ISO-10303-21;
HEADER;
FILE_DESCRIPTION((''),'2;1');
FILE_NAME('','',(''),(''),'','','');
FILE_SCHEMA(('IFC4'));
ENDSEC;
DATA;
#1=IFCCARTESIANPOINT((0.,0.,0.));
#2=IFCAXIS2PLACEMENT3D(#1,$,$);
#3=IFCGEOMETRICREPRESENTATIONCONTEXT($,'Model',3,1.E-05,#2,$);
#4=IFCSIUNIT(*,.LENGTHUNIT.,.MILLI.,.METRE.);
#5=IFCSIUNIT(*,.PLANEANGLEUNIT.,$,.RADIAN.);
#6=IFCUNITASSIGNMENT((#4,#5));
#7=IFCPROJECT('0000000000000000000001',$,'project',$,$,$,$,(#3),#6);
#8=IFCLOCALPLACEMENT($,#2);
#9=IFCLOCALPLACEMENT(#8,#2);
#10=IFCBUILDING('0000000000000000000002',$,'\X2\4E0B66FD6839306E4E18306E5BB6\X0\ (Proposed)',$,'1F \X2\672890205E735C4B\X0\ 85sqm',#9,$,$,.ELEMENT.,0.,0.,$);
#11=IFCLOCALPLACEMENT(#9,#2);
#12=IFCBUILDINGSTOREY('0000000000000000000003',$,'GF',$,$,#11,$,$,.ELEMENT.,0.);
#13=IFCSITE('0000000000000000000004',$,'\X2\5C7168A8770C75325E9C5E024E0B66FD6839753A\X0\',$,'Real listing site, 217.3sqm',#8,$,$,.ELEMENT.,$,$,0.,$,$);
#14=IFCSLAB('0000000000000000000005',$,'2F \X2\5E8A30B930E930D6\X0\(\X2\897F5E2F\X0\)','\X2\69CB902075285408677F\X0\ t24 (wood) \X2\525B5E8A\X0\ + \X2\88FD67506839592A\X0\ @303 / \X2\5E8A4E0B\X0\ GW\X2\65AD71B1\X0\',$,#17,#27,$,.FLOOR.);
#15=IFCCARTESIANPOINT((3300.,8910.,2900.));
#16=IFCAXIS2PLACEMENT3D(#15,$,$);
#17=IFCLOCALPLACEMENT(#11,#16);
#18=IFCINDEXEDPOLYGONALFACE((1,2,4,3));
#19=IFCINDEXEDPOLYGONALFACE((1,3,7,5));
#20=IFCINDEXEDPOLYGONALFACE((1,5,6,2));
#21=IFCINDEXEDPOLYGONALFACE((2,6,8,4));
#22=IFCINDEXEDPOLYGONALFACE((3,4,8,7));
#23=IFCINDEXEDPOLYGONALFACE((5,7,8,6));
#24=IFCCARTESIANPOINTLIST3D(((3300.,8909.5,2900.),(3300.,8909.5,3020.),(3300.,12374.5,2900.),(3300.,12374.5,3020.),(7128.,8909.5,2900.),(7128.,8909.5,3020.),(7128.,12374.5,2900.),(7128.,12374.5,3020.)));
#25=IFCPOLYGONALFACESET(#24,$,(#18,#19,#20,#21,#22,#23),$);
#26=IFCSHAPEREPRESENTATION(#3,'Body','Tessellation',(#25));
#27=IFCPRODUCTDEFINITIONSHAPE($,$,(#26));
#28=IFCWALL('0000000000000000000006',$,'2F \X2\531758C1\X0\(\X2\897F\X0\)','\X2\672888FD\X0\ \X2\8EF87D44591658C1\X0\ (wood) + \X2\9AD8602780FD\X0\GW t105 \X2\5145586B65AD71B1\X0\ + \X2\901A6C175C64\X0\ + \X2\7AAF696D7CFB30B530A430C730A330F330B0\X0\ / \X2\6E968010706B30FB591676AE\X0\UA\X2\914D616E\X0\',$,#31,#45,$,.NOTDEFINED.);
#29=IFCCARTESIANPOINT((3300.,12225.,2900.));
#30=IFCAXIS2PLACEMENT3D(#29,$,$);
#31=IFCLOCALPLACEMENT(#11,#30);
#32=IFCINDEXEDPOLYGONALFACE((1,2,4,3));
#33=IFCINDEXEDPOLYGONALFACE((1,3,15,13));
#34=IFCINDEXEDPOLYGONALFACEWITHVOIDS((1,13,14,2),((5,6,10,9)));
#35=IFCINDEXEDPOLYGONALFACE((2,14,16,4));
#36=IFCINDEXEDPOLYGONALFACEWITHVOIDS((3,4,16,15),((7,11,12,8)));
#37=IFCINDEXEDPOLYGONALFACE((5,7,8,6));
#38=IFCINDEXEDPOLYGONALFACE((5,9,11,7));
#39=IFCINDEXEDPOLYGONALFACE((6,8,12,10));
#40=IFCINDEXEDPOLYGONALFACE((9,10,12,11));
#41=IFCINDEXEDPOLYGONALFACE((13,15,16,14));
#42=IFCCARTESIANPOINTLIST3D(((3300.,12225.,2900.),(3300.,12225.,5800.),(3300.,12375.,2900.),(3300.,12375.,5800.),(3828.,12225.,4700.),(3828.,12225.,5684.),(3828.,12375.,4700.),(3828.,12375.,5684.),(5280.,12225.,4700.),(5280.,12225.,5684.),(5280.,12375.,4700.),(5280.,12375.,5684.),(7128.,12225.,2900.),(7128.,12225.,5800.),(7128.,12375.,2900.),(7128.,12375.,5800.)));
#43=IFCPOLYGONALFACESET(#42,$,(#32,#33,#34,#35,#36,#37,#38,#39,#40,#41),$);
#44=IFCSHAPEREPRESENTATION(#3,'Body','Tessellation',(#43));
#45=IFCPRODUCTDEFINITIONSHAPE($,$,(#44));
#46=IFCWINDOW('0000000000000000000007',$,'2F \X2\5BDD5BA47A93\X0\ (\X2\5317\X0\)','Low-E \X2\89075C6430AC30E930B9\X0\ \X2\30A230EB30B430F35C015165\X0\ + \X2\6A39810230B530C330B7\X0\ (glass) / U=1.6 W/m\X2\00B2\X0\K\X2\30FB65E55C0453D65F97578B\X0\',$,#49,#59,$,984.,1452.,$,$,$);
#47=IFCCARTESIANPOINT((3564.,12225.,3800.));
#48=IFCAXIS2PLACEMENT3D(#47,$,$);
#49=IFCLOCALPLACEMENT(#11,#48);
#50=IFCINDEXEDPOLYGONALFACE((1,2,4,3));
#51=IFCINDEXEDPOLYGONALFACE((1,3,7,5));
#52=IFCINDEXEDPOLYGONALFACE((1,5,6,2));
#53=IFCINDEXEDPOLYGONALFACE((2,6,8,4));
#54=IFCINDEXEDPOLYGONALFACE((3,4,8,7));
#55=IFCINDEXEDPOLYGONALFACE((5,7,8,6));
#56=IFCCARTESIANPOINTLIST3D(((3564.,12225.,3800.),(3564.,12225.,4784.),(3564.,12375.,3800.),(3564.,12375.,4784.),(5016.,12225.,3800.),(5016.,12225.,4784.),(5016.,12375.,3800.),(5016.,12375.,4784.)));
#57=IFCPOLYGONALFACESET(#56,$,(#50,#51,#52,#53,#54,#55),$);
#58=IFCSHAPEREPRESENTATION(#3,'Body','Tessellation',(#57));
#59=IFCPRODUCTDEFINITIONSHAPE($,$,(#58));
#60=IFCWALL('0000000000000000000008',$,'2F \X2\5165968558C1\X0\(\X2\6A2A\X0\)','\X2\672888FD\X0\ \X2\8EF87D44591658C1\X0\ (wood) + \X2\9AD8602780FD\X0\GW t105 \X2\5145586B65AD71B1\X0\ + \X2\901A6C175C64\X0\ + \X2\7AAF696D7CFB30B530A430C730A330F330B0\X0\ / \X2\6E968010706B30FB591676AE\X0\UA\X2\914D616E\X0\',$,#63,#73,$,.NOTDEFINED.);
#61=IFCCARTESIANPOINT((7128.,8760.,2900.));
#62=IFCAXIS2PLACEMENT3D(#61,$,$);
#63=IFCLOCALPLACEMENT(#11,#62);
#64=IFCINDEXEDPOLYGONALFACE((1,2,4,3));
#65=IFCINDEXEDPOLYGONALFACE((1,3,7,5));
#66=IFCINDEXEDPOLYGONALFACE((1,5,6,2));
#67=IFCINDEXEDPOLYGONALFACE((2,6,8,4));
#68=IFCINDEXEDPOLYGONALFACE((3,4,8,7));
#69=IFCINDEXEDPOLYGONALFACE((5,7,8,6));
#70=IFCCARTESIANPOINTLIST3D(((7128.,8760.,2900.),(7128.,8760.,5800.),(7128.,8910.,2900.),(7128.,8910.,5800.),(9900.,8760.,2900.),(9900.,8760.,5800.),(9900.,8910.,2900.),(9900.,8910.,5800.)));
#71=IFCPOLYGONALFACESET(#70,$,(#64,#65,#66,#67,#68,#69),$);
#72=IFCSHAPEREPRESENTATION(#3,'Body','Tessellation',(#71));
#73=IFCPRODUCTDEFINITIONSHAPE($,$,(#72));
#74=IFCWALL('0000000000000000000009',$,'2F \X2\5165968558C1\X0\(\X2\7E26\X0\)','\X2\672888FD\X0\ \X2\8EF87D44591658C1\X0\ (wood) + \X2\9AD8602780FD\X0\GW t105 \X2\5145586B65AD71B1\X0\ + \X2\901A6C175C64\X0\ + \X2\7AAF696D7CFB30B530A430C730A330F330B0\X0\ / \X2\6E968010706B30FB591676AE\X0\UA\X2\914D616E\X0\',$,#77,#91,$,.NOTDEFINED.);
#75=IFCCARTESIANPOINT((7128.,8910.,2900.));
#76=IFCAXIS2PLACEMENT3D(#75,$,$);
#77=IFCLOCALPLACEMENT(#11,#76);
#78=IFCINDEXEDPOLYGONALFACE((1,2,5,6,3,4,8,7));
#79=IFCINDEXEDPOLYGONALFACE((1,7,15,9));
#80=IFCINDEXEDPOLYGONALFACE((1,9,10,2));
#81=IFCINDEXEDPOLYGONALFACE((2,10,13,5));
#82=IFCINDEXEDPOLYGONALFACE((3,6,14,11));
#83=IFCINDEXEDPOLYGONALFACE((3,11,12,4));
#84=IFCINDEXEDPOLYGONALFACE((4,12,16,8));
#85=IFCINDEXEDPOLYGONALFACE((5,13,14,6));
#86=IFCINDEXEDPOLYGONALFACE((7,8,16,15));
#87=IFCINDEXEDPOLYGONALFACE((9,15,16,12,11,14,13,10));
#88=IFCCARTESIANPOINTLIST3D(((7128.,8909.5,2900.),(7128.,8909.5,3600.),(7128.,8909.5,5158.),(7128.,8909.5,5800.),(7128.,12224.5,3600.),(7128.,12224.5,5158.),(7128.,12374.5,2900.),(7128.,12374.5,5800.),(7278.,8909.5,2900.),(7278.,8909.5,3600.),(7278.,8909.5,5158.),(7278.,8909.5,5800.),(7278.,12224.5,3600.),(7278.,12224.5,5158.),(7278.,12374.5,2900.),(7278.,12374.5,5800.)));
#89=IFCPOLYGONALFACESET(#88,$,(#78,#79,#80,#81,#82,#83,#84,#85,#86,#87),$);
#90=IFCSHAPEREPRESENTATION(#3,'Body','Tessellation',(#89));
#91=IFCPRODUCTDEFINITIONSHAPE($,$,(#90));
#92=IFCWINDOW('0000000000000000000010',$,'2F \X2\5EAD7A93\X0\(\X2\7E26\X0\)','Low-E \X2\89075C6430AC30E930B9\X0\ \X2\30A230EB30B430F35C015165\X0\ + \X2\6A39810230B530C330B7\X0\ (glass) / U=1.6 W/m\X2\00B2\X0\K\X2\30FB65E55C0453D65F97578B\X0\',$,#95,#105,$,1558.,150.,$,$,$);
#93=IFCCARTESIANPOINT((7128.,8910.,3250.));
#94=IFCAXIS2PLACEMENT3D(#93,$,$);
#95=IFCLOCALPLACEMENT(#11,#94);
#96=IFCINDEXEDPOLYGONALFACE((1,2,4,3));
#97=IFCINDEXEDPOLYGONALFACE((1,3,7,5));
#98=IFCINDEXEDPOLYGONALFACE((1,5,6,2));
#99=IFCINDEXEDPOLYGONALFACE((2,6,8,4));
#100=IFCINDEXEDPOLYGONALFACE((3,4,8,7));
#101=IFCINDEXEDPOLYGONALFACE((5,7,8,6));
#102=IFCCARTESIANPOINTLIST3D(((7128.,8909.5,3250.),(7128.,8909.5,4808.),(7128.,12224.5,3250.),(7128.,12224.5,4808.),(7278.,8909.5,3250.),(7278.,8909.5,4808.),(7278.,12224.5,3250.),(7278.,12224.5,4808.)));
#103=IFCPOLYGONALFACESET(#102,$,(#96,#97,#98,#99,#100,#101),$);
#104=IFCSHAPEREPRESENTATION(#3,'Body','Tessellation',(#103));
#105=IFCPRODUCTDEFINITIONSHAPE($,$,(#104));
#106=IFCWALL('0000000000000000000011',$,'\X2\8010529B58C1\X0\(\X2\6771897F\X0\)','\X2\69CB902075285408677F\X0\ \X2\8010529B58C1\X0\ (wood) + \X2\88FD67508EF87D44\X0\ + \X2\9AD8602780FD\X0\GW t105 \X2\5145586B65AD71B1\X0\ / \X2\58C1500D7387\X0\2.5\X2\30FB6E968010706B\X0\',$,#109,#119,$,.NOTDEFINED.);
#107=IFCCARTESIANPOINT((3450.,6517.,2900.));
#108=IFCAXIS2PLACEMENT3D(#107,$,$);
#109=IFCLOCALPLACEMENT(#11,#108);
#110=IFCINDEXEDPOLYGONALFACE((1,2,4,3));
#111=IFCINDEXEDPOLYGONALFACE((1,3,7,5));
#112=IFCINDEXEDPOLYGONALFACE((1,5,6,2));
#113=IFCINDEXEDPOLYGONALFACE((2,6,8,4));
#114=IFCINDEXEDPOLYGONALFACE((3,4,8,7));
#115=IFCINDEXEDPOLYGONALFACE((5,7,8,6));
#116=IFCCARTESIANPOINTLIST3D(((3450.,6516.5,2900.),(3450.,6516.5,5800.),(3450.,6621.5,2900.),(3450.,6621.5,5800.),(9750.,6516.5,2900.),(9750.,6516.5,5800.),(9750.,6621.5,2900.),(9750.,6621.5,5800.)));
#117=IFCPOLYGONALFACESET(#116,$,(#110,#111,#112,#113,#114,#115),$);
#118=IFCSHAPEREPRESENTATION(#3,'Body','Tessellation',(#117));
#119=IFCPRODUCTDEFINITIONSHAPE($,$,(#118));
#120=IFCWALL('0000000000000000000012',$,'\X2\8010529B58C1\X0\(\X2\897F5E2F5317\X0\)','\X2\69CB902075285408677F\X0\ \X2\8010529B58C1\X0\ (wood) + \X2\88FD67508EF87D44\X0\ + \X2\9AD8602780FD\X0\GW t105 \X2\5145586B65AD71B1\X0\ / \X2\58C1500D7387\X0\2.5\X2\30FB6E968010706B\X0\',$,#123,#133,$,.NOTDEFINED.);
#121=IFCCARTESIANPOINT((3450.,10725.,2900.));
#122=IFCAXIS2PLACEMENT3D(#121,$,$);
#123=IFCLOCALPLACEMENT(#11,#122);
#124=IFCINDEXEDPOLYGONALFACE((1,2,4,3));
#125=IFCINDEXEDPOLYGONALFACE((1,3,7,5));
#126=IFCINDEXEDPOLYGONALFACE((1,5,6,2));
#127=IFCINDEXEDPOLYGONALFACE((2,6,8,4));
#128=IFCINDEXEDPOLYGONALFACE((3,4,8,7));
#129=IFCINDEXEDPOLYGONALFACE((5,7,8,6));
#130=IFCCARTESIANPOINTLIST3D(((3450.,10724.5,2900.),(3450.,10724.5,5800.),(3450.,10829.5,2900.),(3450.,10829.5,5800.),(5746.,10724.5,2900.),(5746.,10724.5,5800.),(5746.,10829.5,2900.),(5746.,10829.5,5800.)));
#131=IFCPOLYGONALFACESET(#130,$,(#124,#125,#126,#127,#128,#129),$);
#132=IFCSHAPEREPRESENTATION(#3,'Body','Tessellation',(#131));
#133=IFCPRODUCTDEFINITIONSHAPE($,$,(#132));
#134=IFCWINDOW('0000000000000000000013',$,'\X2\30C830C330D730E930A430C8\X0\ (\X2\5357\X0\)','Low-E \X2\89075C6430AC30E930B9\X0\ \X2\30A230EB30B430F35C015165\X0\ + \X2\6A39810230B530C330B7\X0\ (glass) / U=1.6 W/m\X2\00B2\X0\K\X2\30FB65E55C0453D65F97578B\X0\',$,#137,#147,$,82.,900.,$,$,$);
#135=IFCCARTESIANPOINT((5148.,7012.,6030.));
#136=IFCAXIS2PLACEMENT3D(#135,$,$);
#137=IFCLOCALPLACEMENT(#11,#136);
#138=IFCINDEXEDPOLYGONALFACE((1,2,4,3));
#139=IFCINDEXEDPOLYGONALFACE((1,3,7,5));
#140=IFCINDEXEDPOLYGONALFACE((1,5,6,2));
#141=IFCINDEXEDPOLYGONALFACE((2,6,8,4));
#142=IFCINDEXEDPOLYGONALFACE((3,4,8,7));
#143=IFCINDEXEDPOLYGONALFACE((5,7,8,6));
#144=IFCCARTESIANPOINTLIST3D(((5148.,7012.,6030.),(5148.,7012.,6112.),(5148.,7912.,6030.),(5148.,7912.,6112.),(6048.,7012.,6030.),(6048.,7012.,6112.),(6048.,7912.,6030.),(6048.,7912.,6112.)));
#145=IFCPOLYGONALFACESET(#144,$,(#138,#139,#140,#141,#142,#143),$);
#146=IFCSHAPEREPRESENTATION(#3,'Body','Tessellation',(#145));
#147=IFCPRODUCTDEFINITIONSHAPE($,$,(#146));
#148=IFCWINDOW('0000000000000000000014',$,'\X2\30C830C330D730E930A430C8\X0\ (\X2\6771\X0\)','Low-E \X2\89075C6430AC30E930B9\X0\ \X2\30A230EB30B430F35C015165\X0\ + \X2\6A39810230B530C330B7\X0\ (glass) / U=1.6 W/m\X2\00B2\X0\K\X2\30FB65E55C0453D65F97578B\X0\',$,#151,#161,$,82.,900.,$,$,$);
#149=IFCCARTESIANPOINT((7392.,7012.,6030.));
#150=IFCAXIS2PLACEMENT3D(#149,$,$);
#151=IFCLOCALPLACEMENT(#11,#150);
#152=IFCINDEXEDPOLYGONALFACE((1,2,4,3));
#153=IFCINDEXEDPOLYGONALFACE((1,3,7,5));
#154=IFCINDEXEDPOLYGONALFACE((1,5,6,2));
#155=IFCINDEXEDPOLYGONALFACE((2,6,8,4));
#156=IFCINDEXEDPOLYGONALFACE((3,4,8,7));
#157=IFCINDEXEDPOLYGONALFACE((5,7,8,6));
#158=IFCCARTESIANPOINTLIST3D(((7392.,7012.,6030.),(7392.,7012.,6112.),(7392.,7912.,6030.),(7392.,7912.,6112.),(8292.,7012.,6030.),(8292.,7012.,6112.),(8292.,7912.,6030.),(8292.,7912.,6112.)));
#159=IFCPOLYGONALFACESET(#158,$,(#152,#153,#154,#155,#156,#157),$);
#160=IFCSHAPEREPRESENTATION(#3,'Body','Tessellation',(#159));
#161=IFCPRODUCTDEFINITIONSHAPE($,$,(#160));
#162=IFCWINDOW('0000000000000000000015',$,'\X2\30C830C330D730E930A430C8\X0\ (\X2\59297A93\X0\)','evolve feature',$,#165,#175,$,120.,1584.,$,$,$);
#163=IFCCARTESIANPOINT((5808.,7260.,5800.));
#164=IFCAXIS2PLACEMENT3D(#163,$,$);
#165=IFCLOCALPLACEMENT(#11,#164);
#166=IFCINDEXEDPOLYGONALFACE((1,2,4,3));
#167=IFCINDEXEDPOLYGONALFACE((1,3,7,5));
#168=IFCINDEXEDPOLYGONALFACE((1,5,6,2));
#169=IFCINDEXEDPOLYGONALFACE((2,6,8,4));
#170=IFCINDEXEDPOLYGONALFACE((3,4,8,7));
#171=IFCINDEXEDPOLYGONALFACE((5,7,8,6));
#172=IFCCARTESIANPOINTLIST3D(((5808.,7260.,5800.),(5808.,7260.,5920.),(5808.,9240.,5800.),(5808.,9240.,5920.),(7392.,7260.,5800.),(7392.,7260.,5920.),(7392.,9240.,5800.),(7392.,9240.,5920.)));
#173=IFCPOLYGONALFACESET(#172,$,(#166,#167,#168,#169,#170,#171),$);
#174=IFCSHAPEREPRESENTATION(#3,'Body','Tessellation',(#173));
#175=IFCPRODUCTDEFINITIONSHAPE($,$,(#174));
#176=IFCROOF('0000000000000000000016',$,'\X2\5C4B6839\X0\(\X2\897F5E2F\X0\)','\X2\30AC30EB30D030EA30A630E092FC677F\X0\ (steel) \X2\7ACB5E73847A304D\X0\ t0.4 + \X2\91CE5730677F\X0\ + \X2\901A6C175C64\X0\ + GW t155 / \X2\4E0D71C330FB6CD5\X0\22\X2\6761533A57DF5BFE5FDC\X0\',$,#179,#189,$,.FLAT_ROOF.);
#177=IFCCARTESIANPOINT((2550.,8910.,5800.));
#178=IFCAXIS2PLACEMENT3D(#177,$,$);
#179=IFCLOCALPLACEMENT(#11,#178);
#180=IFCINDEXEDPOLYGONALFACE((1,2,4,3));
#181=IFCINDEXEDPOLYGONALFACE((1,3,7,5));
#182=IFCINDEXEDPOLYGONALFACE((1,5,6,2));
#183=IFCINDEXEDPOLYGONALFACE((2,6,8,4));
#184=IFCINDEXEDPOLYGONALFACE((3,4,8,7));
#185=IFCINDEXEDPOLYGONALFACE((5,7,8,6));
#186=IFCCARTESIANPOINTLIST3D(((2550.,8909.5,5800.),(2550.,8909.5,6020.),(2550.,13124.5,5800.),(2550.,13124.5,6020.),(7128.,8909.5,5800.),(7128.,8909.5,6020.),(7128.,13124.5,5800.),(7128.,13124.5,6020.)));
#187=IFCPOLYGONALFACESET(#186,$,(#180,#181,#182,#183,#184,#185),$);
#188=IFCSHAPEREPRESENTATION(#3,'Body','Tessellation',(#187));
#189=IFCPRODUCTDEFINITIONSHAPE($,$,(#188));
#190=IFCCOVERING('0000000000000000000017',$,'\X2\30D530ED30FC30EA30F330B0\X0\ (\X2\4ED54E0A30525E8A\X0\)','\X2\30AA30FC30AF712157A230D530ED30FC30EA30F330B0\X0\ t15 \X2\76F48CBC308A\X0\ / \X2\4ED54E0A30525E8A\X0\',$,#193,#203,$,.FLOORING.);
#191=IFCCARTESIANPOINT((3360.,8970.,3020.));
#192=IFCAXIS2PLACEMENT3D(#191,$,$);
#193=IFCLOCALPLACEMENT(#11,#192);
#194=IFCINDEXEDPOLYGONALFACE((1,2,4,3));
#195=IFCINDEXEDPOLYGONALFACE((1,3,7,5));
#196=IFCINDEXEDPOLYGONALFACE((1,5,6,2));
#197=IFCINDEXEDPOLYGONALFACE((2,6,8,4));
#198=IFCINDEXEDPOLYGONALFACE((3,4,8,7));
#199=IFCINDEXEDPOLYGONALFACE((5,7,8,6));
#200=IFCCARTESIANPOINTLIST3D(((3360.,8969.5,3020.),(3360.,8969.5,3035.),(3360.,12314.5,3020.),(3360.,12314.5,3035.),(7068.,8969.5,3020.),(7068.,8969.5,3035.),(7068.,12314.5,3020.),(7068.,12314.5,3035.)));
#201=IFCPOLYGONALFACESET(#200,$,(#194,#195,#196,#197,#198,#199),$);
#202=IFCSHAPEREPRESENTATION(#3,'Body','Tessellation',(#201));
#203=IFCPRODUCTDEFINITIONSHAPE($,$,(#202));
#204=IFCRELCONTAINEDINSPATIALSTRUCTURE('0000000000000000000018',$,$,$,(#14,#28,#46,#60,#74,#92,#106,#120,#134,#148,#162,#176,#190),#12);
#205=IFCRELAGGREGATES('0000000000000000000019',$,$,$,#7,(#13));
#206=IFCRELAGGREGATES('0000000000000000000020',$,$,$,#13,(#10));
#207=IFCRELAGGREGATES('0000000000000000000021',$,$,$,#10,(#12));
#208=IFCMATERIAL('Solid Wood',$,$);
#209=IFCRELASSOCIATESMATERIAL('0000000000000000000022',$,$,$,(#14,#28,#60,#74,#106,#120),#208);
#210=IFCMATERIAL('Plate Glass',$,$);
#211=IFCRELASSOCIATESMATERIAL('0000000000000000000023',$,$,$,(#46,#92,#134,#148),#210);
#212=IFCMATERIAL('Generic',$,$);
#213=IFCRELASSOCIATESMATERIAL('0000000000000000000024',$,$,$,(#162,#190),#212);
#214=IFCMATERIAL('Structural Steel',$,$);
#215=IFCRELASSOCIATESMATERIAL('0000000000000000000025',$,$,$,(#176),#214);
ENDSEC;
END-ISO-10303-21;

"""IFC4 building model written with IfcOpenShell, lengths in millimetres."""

from ifc_helpers import new_model, si_unit, frame, frame_2d, origin, place, context, project, spatial, rectangle, extrude, material, element, fill, save


model = new_model("IFC4")

# Units and contexts
model_context = context("Model", 3, precision=1e-05, world=origin())
ifc_project = project(units=[si_unit("LENGTHUNIT", "METRE", prefix="MILLI"), si_unit("PLANEANGLEUNIT", "RADIAN")], contexts=[model_context])

# Site, building, storey
site_placement = place(None, origin())
site = spatial("IfcSite", under=ifc_project, at=site_placement, Name="山梨県甲府市下曽根町", ObjectType="Real listing site, 217.3sqm", CompositionType="ELEMENT", RefElevation=0.0)
building_placement = place(site_placement, origin())
building = spatial("IfcBuilding", under=site, at=building_placement, Name="下曽根の丘の家 (Proposed)", ObjectType="1F 木造平屋 85sqm", CompositionType="ELEMENT", ElevationOfRefHeight=0.0, ElevationOfTerrain=0.0)
storey_placement = place(building_placement, origin())
storey = spatial("IfcBuildingStorey", under=building, at=storey_placement, Name="GF", CompositionType="ELEMENT", Elevation=0.0)

# Slab
ifc_material_1 = material(Name="Solid Wood")
slab_placement = place(storey_placement, frame((3300.0, 8910.0, 2900.0)))
element("IfcSlab", 1, at=slab_placement, inside=storey, material=ifc_material_1, Name="2F 床スラブ(西帯)", Description="構造用合板 t24 (wood) 剛床 + 製材根太 @303 / 床下 GW断熱", PredefinedType="FLOOR", context=model_context, shape_type="SweptSolid", body=[
    extrude(rectangle(XDim=3828.0, YDim=3465.0, at=frame_2d((1914.0, 1732.0))), frame((3300.0, 8910.0, 2900.0)), (0.0, 0.0, 1.0), 120.0),
])

# Wall, opening, window
wall_1_placement = place(storey_placement, frame((3300.0, 12225.0, 2900.0)))
wall_1 = element("IfcWall", 2, at=wall_1_placement, inside=storey, material=ifc_material_1, Name="2F 北壁(西)", Description="木製 軸組外壁 (wood) + 高性能GW t105 充填断熱 + 通気層 + 窯業系サイディング / 準耐火・外皮UA配慮", PredefinedType="NOTDEFINED", context=model_context, shape_type="SweptSolid", body=[
    extrude(rectangle(XDim=3828.0, YDim=150.0, at=frame_2d((1914.0, 75.0))), frame((3300.0, 12225.0, 2900.0)), (0.0, 0.0, 1.0), 2900.0),
])
opening_1_placement = place(storey_placement, frame((3564.0, 12225.0, 3800.0)))
opening_1 = element("IfcOpeningElement", 3, at=opening_1_placement, cuts=wall_1, PredefinedType="NOTDEFINED", context=model_context, shape_type="SweptSolid", body=[
    extrude(rectangle(XDim=1452.0, YDim=150.0, at=frame_2d((726.0, 75.0))), frame((3564.0, 12225.0, 3800.0)), (0.0, 0.0, 1.0), 984.0),
])
ifc_material_2 = material(Name="Plate Glass")
window_1_placement = place(storey_placement, frame((3564.0, 12225.0, 3800.0)))
window_1 = element("IfcWindow", 4, at=window_1_placement, inside=storey, material=ifc_material_2, Name="2F 寝室窓 (北)", Description="Low-E 複層ガラス アルゴン封入 + 樹脂サッシ (glass) / U=1.6 W/m²K・日射取得型", OverallHeight=984.0, OverallWidth=1452.0, context=model_context, shape_type="SweptSolid", body=[
    extrude(rectangle(XDim=1452.0, YDim=150.0, at=frame_2d((726.0, 75.0))), frame((3564.0, 12225.0, 3800.0)), (0.0, 0.0, 1.0), 984.0),
])
fill(opening_1, window_1)

# Wall
wall_2_placement = place(storey_placement, frame((7128.0, 8760.0, 2900.0)))
element("IfcWall", 5, at=wall_2_placement, inside=storey, material=ifc_material_1, Name="2F 入隅壁(横)", Description="木製 軸組外壁 (wood) + 高性能GW t105 充填断熱 + 通気層 + 窯業系サイディング / 準耐火・外皮UA配慮", PredefinedType="NOTDEFINED", context=model_context, shape_type="SweptSolid", body=[
    extrude(rectangle(XDim=2772.0, YDim=150.0, at=frame_2d((1386.0, 75.0))), frame((7128.0, 8760.0, 2900.0)), (0.0, 0.0, 1.0), 2900.0),
])

# Wall, opening, window
wall_3_placement = place(storey_placement, frame((7128.0, 8910.0, 2900.0)))
wall_3 = element("IfcWall", 6, at=wall_3_placement, inside=storey, material=ifc_material_1, Name="2F 入隅壁(縦)", Description="木製 軸組外壁 (wood) + 高性能GW t105 充填断熱 + 通気層 + 窯業系サイディング / 準耐火・外皮UA配慮", PredefinedType="NOTDEFINED", context=model_context, shape_type="SweptSolid", body=[
    extrude(rectangle(XDim=150.0, YDim=3465.0, at=frame_2d((75.0, 1732.0))), frame((7128.0, 8910.0, 2900.0)), (0.0, 0.0, 1.0), 2900.0),
])
opening_2_placement = place(storey_placement, frame((7128.0, 8910.0, 3250.0)))
opening_2 = element("IfcOpeningElement", 7, at=opening_2_placement, cuts=wall_3, PredefinedType="NOTDEFINED", context=model_context, shape_type="SweptSolid", body=[
    extrude(rectangle(XDim=150.0, YDim=3315.0, at=frame_2d((75.0, 1657.0))), frame((7128.0, 8910.0, 3250.0)), (0.0, 0.0, 1.0), 1558.0),
])
window_2_placement = place(storey_placement, frame((7128.0, 8910.0, 3250.0)))
window_2 = element("IfcWindow", 8, at=window_2_placement, inside=storey, material=ifc_material_2, Name="2F 庭窓(縦)", Description="Low-E 複層ガラス アルゴン封入 + 樹脂サッシ (glass) / U=1.6 W/m²K・日射取得型", OverallHeight=1558.0, OverallWidth=150.0, context=model_context, shape_type="SweptSolid", body=[
    extrude(rectangle(XDim=150.0, YDim=3315.0, at=frame_2d((75.0, 1657.0))), frame((7128.0, 8910.0, 3250.0)), (0.0, 0.0, 1.0), 1558.0),
])
fill(opening_2, window_2)

# Walls
wall_4_placement = place(storey_placement, frame((3450.0, 6517.0, 2900.0)))
element("IfcWall", 9, at=wall_4_placement, inside=storey, material=ifc_material_1, Name="耐力壁(東西)", Description="構造用合板 耐力壁 (wood) + 製材軸組 + 高性能GW t105 充填断熱 / 壁倍率2.5・準耐火", PredefinedType="NOTDEFINED", context=model_context, shape_type="SweptSolid", body=[
    extrude(rectangle(XDim=6300.0, YDim=105.0, at=frame_2d((3150.0, 52.0))), frame((3450.0, 6517.0, 2900.0)), (0.0, 0.0, 1.0), 2900.0),
])
wall_5_placement = place(storey_placement, frame((3450.0, 10725.0, 2900.0)))
element("IfcWall", 10, at=wall_5_placement, inside=storey, material=ifc_material_1, Name="耐力壁(西帯北)", Description="構造用合板 耐力壁 (wood) + 製材軸組 + 高性能GW t105 充填断熱 / 壁倍率2.5・準耐火", PredefinedType="NOTDEFINED", context=model_context, shape_type="SweptSolid", body=[
    extrude(rectangle(XDim=2296.0, YDim=105.0, at=frame_2d((1148.0, 52.0))), frame((3450.0, 10725.0, 2900.0)), (0.0, 0.0, 1.0), 2900.0),
])

# Windows
window_3_placement = place(storey_placement, frame((5148.0, 7012.0, 6030.0)))
element("IfcWindow", 11, at=window_3_placement, inside=storey, material=ifc_material_2, Name="トップライト (南)", Description="Low-E 複層ガラス アルゴン封入 + 樹脂サッシ (glass) / U=1.6 W/m²K・日射取得型", OverallHeight=82.0, OverallWidth=900.0, context=model_context, shape_type="SweptSolid", body=[
    extrude(rectangle(XDim=900.0, YDim=900.0, at=frame_2d((450.0, 450.0))), frame((5148.0, 7012.0, 6030.0)), (0.0, 0.0, 1.0), 82.0),
])
window_4_placement = place(storey_placement, frame((7392.0, 7012.0, 6030.0)))
element("IfcWindow", 12, at=window_4_placement, inside=storey, material=ifc_material_2, Name="トップライト (東)", Description="Low-E 複層ガラス アルゴン封入 + 樹脂サッシ (glass) / U=1.6 W/m²K・日射取得型", OverallHeight=82.0, OverallWidth=900.0, context=model_context, shape_type="SweptSolid", body=[
    extrude(rectangle(XDim=900.0, YDim=900.0, at=frame_2d((450.0, 450.0))), frame((7392.0, 7012.0, 6030.0)), (0.0, 0.0, 1.0), 82.0),
])
ifc_material_3 = material(Name="Generic")
window_5_placement = place(storey_placement, frame((5808.0, 7260.0, 5800.0)))
element("IfcWindow", 13, at=window_5_placement, inside=storey, material=ifc_material_3, Name="トップライト (天窓)", Description="evolve feature", OverallHeight=120.0, OverallWidth=1584.0, context=model_context, shape_type="SweptSolid", body=[
    extrude(rectangle(XDim=1584.0, YDim=1980.0, at=frame_2d((792.0, 990.0))), frame((5808.0, 7260.0, 5800.0)), (0.0, 0.0, 1.0), 120.0),
])

# Roof
ifc_material_4 = material(Name="Structural Steel")
for number, where, name in (
    (14, (2550.0, 8910.0, 5800.0), "屋根(西帯)"),
):
    element("IfcRoof", number, at=place(storey_placement, frame(where)), inside=storey, material=ifc_material_4, Name=name, Description="ガルバリウム鋼板 (steel) 立平葺き t0.4 + 野地板 + 通気層 + GW t155 / 不燃・法22条区域対応", PredefinedType="FLAT_ROOF", context=model_context, shape_type="SweptSolid", body=[
        extrude(rectangle(XDim=4578.0, YDim=4215.0, at=frame_2d((2289.0, 2107.0))), frame((2550.0, 8910.0, 5800.0)), (0.0, 0.0, 1.0), 220.0),
    ])

# Covering
covering_placement = place(storey_placement, frame((3360.0, 8970.0, 3020.0)))
element("IfcCovering", 15, at=covering_placement, inside=storey, material=ifc_material_3, Name="フローリング (仕上げ床)", Description="オーク無垢フローリング t15 直貼り / 仕上げ床", PredefinedType="FLOORING", context=model_context, shape_type="SweptSolid", body=[
    extrude(rectangle(XDim=3708.0, YDim=3345.0, at=frame_2d((1854.0, 1672.0))), frame((3360.0, 8970.0, 3020.0)), (0.0, 0.0, 1.0), 15.0),
])

save(model, "model.ifc")
